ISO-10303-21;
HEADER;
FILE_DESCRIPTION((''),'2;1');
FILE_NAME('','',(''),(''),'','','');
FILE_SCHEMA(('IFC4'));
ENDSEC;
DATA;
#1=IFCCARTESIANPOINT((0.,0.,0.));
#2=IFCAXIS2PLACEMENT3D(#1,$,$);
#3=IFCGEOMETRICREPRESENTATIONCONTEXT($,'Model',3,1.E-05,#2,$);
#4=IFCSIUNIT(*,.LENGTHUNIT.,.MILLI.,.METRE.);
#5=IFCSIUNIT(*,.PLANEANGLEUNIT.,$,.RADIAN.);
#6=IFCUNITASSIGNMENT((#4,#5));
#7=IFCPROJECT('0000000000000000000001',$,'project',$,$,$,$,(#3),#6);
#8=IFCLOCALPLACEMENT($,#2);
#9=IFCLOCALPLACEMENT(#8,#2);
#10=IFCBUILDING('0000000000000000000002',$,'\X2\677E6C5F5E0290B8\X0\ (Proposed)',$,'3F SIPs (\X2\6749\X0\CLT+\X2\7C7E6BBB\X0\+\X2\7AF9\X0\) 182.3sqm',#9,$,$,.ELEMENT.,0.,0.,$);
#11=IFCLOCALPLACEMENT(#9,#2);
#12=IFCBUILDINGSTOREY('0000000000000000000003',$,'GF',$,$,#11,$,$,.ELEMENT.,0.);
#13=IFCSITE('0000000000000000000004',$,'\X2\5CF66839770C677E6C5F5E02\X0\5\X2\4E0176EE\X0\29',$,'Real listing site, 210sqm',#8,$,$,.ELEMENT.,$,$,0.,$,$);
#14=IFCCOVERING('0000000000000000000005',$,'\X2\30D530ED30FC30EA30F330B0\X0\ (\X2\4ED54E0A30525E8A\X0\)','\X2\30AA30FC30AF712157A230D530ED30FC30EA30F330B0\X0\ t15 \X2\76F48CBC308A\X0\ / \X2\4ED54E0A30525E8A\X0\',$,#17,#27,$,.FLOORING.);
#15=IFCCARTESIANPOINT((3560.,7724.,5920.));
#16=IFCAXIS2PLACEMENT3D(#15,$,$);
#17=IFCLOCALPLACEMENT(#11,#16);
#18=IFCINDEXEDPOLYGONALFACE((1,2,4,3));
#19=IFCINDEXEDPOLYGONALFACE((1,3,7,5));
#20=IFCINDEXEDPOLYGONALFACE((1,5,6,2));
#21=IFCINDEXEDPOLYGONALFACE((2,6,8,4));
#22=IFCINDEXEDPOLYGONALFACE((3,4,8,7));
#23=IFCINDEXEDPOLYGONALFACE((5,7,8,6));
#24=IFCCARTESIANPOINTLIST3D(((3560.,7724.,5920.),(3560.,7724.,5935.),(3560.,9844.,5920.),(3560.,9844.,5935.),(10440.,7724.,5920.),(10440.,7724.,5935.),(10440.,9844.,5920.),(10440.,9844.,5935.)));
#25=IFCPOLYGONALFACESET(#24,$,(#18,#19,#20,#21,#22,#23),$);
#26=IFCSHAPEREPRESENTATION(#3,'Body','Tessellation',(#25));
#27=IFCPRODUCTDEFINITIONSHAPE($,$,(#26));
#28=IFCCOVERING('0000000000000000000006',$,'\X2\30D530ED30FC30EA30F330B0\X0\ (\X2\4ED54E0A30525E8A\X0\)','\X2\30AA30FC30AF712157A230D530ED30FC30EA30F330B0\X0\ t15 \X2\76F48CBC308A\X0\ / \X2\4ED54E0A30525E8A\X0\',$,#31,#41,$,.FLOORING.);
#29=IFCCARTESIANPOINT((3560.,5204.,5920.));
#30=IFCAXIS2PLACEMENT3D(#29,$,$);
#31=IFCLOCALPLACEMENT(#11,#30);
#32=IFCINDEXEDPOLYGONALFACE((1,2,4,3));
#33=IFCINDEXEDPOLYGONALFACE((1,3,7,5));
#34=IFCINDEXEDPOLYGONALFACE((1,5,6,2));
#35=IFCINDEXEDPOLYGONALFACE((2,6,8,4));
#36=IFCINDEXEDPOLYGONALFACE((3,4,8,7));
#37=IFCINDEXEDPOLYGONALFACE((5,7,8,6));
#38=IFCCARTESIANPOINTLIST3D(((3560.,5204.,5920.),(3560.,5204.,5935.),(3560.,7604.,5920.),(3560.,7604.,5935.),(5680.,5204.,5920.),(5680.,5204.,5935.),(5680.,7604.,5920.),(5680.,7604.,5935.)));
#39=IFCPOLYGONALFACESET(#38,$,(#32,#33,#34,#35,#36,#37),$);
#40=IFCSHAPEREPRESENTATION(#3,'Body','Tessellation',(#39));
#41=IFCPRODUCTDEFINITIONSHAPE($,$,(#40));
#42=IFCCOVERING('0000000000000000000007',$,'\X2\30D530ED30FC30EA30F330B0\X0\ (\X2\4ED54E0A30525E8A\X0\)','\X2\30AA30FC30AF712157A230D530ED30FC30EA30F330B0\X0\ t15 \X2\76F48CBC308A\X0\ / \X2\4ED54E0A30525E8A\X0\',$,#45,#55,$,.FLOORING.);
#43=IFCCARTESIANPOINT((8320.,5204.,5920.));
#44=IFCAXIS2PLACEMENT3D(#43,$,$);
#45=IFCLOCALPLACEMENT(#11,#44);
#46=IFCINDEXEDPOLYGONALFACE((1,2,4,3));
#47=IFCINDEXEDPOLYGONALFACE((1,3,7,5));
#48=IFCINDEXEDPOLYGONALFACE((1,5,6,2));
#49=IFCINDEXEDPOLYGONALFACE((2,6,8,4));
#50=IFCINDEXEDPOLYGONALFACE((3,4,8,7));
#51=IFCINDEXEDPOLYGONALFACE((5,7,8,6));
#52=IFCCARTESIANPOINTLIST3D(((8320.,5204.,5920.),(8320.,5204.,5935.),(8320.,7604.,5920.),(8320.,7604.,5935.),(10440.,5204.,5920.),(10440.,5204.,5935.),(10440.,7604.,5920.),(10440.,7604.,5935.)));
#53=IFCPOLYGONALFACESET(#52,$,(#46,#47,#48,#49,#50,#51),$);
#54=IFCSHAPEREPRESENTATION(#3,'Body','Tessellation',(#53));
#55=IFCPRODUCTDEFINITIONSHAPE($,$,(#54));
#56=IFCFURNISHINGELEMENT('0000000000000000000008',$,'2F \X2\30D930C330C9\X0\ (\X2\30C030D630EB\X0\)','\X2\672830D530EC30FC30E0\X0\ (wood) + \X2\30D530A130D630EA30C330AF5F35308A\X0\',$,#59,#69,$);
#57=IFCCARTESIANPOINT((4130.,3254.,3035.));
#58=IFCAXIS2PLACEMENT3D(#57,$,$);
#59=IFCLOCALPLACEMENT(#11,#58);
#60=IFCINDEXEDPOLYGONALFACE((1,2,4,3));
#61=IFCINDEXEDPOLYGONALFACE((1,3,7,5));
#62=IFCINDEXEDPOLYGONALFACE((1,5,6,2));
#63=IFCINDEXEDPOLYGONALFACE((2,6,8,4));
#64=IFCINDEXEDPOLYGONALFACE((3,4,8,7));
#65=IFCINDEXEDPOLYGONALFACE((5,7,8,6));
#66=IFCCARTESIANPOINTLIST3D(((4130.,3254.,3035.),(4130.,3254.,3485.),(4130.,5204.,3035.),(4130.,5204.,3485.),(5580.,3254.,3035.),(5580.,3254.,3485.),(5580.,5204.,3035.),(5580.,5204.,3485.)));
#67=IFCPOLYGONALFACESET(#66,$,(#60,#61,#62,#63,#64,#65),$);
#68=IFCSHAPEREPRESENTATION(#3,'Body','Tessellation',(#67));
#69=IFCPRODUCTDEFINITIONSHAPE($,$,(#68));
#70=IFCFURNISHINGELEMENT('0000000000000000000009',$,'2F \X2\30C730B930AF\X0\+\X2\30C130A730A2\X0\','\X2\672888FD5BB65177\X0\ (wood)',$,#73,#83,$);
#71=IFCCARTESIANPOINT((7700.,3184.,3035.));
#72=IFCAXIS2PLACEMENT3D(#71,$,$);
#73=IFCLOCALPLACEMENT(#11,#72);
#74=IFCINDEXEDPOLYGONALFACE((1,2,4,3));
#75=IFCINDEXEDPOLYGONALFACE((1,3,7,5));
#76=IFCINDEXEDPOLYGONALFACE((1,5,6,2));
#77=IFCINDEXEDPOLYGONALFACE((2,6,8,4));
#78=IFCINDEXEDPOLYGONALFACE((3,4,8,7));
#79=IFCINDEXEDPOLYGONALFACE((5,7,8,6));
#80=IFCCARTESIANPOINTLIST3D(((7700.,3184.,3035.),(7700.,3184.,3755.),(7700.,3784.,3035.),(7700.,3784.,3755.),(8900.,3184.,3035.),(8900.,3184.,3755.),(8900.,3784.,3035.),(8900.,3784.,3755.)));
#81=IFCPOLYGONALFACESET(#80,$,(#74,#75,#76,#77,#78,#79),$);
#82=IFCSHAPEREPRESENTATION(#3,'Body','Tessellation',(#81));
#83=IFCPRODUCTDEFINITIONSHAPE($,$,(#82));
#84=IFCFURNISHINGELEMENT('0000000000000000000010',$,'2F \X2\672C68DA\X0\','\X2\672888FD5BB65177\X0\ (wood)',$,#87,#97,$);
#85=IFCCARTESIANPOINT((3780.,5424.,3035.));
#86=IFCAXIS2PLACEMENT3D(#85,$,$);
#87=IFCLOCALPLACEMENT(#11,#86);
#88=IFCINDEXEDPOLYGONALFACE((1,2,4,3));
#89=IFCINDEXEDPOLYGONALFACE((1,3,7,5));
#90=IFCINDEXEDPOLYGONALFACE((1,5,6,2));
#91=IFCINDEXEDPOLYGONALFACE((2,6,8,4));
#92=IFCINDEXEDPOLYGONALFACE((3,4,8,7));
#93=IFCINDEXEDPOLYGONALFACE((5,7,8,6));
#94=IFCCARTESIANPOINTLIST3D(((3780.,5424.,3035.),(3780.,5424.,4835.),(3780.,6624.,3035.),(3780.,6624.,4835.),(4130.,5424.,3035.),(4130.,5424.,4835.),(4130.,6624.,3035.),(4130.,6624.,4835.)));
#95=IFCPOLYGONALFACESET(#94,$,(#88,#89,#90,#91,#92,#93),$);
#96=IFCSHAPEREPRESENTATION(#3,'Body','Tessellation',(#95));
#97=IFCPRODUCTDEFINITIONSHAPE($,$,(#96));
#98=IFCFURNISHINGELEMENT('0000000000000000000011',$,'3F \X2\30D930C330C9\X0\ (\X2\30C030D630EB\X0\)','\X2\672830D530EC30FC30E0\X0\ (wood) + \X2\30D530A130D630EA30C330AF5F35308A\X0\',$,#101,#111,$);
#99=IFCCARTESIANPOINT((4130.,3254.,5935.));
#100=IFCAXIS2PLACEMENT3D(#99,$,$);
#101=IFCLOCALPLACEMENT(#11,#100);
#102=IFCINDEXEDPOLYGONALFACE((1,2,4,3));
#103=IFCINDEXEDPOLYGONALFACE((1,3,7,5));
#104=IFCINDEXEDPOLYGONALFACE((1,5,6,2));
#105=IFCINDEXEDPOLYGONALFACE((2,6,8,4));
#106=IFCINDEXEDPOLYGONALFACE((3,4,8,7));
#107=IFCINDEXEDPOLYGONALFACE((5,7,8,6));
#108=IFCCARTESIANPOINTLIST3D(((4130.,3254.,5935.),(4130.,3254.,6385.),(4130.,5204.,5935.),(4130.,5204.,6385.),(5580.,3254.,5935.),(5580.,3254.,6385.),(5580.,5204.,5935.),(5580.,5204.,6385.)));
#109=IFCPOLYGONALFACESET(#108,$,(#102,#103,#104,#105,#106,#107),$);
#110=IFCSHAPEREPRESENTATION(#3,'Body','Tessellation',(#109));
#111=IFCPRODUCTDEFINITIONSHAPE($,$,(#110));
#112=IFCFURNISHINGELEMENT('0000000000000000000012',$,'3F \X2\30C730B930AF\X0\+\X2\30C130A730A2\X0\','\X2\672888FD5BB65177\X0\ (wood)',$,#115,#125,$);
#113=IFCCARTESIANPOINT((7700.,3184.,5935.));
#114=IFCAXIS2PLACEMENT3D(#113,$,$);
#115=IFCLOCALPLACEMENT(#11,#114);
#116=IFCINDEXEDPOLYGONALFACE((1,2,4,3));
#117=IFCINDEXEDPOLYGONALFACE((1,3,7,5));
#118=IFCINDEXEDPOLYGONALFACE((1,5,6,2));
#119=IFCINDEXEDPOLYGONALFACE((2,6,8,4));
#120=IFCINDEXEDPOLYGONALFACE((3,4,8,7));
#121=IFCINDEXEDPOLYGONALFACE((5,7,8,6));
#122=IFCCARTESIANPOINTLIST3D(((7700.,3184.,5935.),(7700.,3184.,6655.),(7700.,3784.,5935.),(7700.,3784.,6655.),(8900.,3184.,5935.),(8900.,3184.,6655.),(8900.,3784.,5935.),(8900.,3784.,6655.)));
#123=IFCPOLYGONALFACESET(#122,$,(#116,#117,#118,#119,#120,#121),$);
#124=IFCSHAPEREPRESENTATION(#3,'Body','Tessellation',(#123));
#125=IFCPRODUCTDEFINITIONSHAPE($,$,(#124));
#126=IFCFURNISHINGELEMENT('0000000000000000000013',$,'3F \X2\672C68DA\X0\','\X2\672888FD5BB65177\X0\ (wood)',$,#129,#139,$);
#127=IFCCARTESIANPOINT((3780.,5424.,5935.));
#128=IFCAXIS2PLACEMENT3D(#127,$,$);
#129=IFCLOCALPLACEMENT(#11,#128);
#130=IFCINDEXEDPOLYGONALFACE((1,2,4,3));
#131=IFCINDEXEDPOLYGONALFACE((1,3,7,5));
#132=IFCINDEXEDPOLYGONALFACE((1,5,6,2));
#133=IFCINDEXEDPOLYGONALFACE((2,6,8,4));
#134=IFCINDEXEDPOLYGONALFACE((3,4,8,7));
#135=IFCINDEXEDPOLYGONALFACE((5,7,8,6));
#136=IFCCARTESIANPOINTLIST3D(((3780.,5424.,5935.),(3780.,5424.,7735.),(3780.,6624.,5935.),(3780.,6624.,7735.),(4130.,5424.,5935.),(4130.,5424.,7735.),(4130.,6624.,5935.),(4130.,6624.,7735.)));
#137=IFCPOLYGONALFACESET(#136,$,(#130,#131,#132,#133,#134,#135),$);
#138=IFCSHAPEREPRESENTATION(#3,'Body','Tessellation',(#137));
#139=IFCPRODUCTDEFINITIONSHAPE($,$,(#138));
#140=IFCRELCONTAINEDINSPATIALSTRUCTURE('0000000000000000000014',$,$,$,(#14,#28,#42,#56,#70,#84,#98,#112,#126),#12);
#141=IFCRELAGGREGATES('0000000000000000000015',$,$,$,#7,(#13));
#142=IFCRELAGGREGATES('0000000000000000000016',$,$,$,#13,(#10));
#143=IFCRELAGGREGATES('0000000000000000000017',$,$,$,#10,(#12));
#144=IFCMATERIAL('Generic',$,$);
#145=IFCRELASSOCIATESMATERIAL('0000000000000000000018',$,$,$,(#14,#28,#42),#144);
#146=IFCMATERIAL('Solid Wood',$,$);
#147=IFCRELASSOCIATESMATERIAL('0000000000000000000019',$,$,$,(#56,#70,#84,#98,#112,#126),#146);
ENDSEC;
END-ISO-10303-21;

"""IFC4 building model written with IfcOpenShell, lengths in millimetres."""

from ifc_helpers import new_model, si_unit, frame, frame_2d, origin, place, context, project, spatial, rectangle, extrude, material, element, save


model = new_model("IFC4")

# Units and contexts
model_context = context("Model", 3, precision=1e-05, world=origin())
ifc_project = project(units=[si_unit("LENGTHUNIT", "METRE", prefix="MILLI"), si_unit("PLANEANGLEUNIT", "RADIAN")], contexts=[model_context])

# Site, building, storey
site_placement = place(None, origin())
site = spatial("IfcSite", under=ifc_project, at=site_placement, Name="島根県松江市5丁目29", ObjectType="Real listing site, 210sqm", CompositionType="ELEMENT", RefElevation=0.0)
building_placement = place(site_placement, origin())
building = spatial("IfcBuilding", under=site, at=building_placement, Name="松江市邸 (Proposed)", ObjectType="3F SIPs (杉CLT+籾殻+竹) 182.3sqm", CompositionType="ELEMENT", ElevationOfRefHeight=0.0, ElevationOfTerrain=0.0)
storey_placement = place(building_placement, origin())
storey = spatial("IfcBuildingStorey", under=building, at=storey_placement, Name="GF", CompositionType="ELEMENT", Elevation=0.0)

# Shared definitions
ifc_material_1 = material(Name="Solid Wood")

# Shared definitions
ifc_material_2 = material(Name="Generic")

# Coverings
covering_1_placement = place(storey_placement, frame((3560.0, 7724.0, 5920.0)))
element("IfcCovering", 1, at=covering_1_placement, inside=storey, material=ifc_material_2, Name="フローリング (仕上げ床)", Description="オーク無垢フローリング t15 直貼り / 仕上げ床", PredefinedType="FLOORING", context=model_context, shape_type="SweptSolid", body=[
    extrude(rectangle(XDim=6880.0, YDim=2120.0, at=frame_2d((3440.0, 1060.0))), frame((3560.0, 7724.0, 5920.0)), (0.0, 0.0, 1.0), 15.0),
])
covering_2_placement = place(storey_placement, frame((3560.0, 5204.0, 5920.0)))
element("IfcCovering", 2, at=covering_2_placement, inside=storey, material=ifc_material_2, Name="フローリング (仕上げ床)", Description="オーク無垢フローリング t15 直貼り / 仕上げ床", PredefinedType="FLOORING", context=model_context, shape_type="SweptSolid", body=[
    extrude(rectangle(XDim=2120.0, YDim=2400.0, at=frame_2d((1060.0, 1200.0))), frame((3560.0, 5204.0, 5920.0)), (0.0, 0.0, 1.0), 15.0),
])
covering_3_placement = place(storey_placement, frame((8320.0, 5204.0, 5920.0)))
element("IfcCovering", 3, at=covering_3_placement, inside=storey, material=ifc_material_2, Name="フローリング (仕上げ床)", Description="オーク無垢フローリング t15 直貼り / 仕上げ床", PredefinedType="FLOORING", context=model_context, shape_type="SweptSolid", body=[
    extrude(rectangle(XDim=2120.0, YDim=2400.0, at=frame_2d((1060.0, 1200.0))), frame((8320.0, 5204.0, 5920.0)), (0.0, 0.0, 1.0), 15.0),
])

# Furnishing elements
furnishing_1_placement = place(storey_placement, frame((4130.0, 3254.0, 3035.0)))
element("IfcFurnishingElement", 4, at=furnishing_1_placement, inside=storey, material=ifc_material_1, Name="2F ベッド (ダブル)", Description="木フレーム (wood) + ファブリック張り", context=model_context, shape_type="SweptSolid", body=[
    extrude(rectangle(XDim=1450.0, YDim=1950.0, at=frame_2d((725.0, 975.0))), frame((4130.0, 3254.0, 3035.0)), (0.0, 0.0, 1.0), 450.0),
])
furnishing_2_placement = place(storey_placement, frame((7700.0, 3184.0, 3035.0)))
element("IfcFurnishingElement", 5, at=furnishing_2_placement, inside=storey, material=ifc_material_1, Name="2F デスク+チェア", Description="木製家具 (wood)", context=model_context, shape_type="SweptSolid", body=[
    extrude(rectangle(XDim=1200.0, YDim=600.0, at=frame_2d((600.0, 300.0))), frame((7700.0, 3184.0, 3035.0)), (0.0, 0.0, 1.0), 720.0),
])
furnishing_3_placement = place(storey_placement, frame((3780.0, 5424.0, 3035.0)))
element("IfcFurnishingElement", 6, at=furnishing_3_placement, inside=storey, material=ifc_material_1, Name="2F 本棚", Description="木製家具 (wood)", context=model_context, shape_type="SweptSolid", body=[
    extrude(rectangle(XDim=350.0, YDim=1200.0, at=frame_2d((175.0, 600.0))), frame((3780.0, 5424.0, 3035.0)), (0.0, 0.0, 1.0), 1800.0),
])
furnishing_4_placement = place(storey_placement, frame((4130.0, 3254.0, 5935.0)))
element("IfcFurnishingElement", 7, at=furnishing_4_placement, inside=storey, material=ifc_material_1, Name="3F ベッド (ダブル)", Description="木フレーム (wood) + ファブリック張り", context=model_context, shape_type="SweptSolid", body=[
    extrude(rectangle(XDim=1450.0, YDim=1950.0, at=frame_2d((725.0, 975.0))), frame((4130.0, 3254.0, 5935.0)), (0.0, 0.0, 1.0), 450.0),
])
furnishing_5_placement = place(storey_placement, frame((7700.0, 3184.0, 5935.0)))
element("IfcFurnishingElement", 8, at=furnishing_5_placement, inside=storey, material=ifc_material_1, Name="3F デスク+チェア", Description="木製家具 (wood)", context=model_context, shape_type="SweptSolid", body=[
    extrude(rectangle(XDim=1200.0, YDim=600.0, at=frame_2d((600.0, 300.0))), frame((7700.0, 3184.0, 5935.0)), (0.0, 0.0, 1.0), 720.0),
])
furnishing_6_placement = place(storey_placement, frame((3780.0, 5424.0, 5935.0)))
element("IfcFurnishingElement", 9, at=furnishing_6_placement, inside=storey, material=ifc_material_1, Name="3F 本棚", Description="木製家具 (wood)", context=model_context, shape_type="SweptSolid", body=[
    extrude(rectangle(XDim=350.0, YDim=1200.0, at=frame_2d((175.0, 600.0))), frame((3780.0, 5424.0, 5935.0)), (0.0, 0.0, 1.0), 1800.0),
])

save(model, "model.ifc")
